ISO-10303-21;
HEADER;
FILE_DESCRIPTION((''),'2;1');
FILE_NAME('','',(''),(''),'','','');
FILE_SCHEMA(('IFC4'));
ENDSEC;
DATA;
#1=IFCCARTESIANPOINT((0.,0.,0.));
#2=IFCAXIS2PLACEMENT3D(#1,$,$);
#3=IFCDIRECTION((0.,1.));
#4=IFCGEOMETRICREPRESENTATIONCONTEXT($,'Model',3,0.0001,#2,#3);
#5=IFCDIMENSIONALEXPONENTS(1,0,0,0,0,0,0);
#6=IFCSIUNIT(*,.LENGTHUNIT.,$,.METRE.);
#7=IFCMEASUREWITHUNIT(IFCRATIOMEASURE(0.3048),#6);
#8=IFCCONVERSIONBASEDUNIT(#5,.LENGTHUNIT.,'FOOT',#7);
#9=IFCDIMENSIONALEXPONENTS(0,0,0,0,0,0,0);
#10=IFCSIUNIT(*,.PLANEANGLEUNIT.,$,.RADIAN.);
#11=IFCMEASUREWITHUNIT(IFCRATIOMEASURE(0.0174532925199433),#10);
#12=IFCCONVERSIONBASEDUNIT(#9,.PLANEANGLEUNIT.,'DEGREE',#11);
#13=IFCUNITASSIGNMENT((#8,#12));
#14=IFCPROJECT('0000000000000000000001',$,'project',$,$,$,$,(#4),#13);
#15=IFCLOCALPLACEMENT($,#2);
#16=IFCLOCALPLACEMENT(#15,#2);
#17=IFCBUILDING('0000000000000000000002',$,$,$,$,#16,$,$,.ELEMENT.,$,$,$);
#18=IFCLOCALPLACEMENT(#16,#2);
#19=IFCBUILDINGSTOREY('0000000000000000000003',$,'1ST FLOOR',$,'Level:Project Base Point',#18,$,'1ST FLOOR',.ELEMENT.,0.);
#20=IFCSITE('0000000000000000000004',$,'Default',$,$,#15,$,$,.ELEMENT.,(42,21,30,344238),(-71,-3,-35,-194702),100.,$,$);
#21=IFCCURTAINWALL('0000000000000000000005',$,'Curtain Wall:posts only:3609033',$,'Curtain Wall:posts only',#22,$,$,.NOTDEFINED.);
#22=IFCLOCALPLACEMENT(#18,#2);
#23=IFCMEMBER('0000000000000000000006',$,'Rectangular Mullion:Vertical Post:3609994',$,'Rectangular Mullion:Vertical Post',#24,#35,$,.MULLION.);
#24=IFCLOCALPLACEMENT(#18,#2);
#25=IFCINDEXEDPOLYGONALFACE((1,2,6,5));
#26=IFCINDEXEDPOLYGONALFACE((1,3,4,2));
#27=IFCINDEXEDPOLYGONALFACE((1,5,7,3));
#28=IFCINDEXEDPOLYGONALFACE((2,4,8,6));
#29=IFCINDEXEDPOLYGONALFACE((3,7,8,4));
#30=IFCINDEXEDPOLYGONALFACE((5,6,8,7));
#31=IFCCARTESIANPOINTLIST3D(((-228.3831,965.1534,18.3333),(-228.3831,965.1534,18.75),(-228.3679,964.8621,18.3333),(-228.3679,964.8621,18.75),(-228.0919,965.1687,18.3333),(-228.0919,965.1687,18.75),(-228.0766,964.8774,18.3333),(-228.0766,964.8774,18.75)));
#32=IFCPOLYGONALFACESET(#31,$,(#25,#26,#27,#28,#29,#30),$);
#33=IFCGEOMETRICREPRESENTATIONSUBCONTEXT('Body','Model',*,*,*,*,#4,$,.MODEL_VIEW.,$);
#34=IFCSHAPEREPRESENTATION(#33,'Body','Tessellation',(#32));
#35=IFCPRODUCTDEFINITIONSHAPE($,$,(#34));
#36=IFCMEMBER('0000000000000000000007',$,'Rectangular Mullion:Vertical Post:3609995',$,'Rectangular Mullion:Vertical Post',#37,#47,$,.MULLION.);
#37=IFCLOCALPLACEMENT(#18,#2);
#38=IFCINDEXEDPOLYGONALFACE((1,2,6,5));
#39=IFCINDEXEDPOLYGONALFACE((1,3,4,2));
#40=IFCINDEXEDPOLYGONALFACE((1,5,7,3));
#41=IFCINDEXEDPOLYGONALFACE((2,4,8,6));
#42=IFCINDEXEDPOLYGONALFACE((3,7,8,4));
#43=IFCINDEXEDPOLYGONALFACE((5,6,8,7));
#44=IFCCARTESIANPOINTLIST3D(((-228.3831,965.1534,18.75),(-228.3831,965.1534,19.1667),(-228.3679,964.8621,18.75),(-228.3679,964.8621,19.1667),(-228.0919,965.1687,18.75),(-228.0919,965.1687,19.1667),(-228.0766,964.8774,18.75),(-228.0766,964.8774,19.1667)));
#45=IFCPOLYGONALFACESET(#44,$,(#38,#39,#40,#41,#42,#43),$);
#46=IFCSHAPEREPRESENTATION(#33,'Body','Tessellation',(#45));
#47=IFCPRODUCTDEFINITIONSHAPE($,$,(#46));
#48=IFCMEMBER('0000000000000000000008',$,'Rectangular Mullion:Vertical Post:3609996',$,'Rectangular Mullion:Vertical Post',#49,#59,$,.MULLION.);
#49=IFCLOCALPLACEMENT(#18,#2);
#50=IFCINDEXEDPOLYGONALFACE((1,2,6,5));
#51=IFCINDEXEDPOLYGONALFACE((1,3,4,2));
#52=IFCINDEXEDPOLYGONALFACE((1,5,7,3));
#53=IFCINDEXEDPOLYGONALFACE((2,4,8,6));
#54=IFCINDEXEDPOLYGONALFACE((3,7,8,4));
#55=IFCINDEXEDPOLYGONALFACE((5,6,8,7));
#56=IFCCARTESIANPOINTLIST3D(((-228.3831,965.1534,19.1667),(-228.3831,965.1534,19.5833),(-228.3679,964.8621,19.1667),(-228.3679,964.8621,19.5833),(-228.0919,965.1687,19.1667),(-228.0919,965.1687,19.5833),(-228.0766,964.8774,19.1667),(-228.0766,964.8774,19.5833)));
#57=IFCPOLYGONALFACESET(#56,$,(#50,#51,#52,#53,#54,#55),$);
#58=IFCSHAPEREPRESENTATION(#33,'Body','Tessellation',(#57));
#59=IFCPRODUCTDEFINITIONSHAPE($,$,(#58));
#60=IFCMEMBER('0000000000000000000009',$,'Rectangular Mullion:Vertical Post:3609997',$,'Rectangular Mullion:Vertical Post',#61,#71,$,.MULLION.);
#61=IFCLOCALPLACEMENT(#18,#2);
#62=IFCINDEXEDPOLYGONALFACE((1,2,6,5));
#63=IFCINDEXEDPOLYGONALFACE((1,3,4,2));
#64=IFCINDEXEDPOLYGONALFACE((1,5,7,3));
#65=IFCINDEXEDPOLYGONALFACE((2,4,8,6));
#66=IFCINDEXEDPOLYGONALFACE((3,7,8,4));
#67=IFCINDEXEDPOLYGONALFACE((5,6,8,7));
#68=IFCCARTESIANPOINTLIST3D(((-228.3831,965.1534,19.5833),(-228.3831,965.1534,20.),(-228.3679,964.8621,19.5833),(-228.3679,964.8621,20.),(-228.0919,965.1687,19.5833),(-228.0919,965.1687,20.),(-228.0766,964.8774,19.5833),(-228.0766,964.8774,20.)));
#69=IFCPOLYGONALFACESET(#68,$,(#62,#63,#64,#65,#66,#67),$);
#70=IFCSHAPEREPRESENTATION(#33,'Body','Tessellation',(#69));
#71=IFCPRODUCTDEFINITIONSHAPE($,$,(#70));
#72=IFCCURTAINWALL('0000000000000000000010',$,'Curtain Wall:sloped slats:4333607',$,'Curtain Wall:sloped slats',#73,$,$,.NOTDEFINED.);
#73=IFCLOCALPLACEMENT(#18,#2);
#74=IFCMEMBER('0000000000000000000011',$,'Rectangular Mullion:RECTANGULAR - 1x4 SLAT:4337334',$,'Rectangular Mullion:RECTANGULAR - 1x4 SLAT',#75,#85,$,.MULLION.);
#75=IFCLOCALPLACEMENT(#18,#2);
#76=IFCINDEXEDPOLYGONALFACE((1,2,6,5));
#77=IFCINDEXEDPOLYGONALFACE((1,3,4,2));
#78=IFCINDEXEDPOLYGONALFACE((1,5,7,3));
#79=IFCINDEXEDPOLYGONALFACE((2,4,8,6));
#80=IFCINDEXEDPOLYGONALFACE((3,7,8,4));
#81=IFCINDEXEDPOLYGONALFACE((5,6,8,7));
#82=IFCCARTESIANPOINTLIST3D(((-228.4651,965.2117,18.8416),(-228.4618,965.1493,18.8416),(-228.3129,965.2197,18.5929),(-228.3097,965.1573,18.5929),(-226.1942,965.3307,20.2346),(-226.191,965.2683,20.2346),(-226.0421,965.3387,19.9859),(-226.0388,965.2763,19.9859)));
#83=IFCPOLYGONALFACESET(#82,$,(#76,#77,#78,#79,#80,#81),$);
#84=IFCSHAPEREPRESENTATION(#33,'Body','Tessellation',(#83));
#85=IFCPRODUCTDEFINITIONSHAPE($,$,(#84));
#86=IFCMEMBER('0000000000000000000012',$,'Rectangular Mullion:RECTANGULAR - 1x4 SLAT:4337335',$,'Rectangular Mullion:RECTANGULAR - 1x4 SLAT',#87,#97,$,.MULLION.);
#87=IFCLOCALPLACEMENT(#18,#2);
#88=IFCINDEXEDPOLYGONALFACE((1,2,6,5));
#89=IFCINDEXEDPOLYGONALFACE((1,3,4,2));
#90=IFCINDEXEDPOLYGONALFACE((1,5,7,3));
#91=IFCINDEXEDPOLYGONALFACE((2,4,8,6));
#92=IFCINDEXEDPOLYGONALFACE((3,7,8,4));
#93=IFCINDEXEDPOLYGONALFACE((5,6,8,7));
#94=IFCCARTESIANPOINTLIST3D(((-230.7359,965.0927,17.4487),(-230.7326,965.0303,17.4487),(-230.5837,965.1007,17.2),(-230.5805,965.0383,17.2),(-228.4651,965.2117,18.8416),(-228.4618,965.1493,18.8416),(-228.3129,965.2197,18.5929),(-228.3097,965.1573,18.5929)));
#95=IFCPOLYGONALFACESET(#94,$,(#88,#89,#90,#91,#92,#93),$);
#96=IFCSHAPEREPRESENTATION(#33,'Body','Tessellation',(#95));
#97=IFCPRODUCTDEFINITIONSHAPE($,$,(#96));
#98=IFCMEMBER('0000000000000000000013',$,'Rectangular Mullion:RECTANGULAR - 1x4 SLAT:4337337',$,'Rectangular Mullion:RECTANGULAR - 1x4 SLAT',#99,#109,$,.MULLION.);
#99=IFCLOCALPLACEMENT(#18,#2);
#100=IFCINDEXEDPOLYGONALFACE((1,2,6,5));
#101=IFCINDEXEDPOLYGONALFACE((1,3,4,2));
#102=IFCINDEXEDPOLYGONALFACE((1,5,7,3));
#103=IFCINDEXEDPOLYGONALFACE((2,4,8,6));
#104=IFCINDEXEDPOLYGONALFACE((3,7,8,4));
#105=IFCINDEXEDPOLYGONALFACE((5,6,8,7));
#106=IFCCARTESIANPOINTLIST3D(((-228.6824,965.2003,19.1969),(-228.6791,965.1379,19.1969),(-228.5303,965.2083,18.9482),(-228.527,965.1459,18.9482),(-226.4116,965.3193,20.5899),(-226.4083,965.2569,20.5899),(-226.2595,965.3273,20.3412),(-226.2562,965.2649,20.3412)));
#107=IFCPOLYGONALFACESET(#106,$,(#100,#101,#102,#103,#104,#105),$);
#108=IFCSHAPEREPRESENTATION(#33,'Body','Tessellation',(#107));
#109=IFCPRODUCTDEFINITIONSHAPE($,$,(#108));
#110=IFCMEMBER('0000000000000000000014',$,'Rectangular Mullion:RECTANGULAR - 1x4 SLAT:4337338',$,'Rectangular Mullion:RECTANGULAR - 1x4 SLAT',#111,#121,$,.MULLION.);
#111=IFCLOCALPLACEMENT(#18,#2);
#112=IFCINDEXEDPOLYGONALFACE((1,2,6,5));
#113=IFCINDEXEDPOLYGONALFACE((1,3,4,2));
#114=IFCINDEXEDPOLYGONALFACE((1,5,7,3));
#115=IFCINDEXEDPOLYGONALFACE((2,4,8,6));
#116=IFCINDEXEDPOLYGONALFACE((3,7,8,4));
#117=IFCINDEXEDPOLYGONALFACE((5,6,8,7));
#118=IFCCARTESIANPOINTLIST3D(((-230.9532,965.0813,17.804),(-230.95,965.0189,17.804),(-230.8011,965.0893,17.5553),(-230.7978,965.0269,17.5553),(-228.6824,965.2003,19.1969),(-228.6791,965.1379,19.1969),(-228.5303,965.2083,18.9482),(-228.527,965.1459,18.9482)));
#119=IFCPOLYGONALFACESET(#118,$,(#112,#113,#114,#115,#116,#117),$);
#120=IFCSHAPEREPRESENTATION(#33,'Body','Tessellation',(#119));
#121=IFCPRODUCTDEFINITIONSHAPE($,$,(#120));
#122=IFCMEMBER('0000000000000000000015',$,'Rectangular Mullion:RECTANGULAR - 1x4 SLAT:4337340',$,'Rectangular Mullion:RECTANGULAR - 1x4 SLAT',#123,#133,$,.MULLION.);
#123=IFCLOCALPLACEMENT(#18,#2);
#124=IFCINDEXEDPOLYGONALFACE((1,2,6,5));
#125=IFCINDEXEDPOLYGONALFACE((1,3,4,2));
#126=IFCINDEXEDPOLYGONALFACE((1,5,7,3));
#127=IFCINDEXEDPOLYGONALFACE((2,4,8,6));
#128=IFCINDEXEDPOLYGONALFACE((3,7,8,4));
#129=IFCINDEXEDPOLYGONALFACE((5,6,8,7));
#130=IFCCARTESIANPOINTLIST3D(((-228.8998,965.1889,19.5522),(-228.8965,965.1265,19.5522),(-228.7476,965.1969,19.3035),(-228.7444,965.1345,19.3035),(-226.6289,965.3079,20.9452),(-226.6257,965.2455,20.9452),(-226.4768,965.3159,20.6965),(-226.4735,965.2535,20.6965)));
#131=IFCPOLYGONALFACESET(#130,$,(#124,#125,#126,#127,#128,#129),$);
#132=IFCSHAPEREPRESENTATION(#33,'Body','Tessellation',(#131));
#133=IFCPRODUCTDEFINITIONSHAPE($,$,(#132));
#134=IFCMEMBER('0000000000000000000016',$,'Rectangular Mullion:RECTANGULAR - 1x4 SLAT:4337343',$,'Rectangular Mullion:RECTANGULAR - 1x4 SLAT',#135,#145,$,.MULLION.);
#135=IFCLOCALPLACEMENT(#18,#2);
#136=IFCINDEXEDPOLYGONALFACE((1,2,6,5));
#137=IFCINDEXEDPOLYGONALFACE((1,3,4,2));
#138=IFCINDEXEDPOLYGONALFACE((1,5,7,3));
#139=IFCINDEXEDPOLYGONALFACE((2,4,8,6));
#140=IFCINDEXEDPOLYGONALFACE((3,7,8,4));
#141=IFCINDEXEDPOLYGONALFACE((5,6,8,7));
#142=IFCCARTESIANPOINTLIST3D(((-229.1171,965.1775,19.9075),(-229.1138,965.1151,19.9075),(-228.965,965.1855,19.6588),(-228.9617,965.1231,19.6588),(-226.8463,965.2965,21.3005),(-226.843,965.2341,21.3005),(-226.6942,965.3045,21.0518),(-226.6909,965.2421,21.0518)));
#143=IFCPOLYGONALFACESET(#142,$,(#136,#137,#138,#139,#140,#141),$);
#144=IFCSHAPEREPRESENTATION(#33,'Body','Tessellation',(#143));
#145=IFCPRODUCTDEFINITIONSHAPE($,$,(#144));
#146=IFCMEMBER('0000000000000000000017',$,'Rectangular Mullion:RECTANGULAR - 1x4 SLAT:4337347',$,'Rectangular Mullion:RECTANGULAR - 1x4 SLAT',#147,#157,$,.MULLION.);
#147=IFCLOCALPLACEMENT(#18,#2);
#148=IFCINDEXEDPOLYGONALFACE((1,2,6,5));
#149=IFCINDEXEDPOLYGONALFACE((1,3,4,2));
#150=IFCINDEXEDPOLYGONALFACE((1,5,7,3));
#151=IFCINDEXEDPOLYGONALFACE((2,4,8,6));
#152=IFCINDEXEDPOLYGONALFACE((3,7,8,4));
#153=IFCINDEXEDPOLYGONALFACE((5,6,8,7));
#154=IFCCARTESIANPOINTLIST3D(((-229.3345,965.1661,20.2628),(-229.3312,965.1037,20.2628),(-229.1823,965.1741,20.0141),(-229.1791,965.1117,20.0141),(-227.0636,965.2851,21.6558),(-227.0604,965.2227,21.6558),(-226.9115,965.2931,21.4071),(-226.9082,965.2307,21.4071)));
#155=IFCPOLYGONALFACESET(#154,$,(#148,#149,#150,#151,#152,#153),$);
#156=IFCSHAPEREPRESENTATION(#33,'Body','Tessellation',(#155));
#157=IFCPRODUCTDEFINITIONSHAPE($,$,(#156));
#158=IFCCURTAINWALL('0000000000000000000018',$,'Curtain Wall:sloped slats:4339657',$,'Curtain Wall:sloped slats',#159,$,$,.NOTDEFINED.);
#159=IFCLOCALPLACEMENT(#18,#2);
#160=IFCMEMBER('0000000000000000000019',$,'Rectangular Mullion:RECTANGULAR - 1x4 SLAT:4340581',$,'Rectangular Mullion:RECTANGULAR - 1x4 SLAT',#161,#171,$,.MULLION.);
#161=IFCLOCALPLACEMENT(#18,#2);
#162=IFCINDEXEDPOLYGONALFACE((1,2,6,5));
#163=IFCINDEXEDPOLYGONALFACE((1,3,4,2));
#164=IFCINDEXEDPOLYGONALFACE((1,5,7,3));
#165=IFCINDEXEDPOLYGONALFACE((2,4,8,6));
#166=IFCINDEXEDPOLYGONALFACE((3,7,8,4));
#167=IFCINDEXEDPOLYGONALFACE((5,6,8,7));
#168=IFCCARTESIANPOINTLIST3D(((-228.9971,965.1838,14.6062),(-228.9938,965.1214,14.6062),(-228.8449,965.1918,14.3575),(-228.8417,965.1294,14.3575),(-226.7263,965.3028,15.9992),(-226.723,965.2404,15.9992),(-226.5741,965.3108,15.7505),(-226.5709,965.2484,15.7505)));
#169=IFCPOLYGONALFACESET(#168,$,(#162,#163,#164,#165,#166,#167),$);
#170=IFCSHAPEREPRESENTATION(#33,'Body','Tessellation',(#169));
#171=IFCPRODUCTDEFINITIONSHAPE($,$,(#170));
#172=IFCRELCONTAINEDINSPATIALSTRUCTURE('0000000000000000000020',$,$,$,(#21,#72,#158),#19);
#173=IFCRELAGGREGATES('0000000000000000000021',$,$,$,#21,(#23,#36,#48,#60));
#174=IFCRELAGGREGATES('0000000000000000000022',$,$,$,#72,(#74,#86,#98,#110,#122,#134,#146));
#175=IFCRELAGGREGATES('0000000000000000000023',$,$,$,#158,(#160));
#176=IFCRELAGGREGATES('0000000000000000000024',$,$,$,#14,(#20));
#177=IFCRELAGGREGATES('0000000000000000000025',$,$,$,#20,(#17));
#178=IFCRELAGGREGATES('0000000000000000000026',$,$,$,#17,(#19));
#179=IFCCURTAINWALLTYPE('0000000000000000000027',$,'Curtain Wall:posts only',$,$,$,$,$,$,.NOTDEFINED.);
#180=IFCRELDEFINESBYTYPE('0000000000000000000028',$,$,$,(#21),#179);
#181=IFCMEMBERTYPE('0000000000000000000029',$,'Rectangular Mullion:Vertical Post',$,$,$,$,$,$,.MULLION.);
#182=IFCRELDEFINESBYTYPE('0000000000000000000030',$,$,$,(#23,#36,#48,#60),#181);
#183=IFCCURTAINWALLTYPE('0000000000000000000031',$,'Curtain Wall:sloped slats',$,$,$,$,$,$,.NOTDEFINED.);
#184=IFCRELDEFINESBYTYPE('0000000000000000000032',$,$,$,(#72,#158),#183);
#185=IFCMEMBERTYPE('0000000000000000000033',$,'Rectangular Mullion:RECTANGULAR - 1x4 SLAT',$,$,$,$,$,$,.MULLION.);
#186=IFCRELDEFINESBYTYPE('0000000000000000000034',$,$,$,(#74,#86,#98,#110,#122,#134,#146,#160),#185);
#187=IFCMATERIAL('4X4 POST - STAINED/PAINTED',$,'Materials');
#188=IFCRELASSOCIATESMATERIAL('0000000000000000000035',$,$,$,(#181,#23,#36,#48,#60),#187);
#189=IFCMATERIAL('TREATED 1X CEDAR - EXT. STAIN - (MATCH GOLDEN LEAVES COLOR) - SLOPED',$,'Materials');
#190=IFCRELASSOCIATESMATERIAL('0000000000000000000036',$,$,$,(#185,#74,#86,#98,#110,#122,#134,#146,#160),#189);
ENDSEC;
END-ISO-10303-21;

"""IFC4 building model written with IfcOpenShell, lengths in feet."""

from ifc_helpers import new_model, entity, si_unit, converted_unit, direction, frame, frame_2d, origin, origin_2d_with_axis, place, context, subcontext, project, spatial, rectangle, extrude, source, transform, mapped, material, material_profile, profile_set, profile_usage, type_object, type_shapes, element, aggregate, save


model = new_model("IFC4")

# Units and contexts
model_context = context("Model", 3, precision=0.0001, world=origin(), true_north=direction((0.0, 1.0)))
body_context = subcontext(model_context, "Body", "Model", "MODEL_VIEW")
ifc_project = project(units=[converted_unit("LENGTHUNIT", "FOOT", entity("IfcRatioMeasure", 0.3048), si_unit("LENGTHUNIT", "METRE"), dimensions=[1, 0, 0, 0, 0, 0, 0]), converted_unit("PLANEANGLEUNIT", "DEGREE", entity("IfcRatioMeasure", 0.0174532925199433), si_unit("PLANEANGLEUNIT", "RADIAN"), dimensions=[0, 0, 0, 0, 0, 0, 0])], contexts=[model_context])

# Site, building, storey
site_placement = place(None, origin())
site = spatial("IfcSite", under=ifc_project, at=site_placement, Name="Default", CompositionType="ELEMENT", RefLatitude=(42, 21, 30, 344238), RefLongitude=(-71, -3, -35, -194702), RefElevation=100.0)
building_placement = place(site_placement, origin())
building = spatial("IfcBuilding", under=site, at=building_placement, CompositionType="ELEMENT")
storey_placement = place(building_placement, origin())
storey = spatial("IfcBuildingStorey", under=building, at=storey_placement, Name="1ST FLOOR", ObjectType="Level:Project Base Point", LongName="1ST FLOOR", CompositionType="ELEMENT", Elevation=0.0)

# Curtain walls, members
curtain_wall_type_1 = type_object("IfcCurtainWallType", Name="Curtain Wall:posts only", PredefinedType="NOTDEFINED")
curtain_wall_1_placement = place(storey_placement, origin())
curtain_wall_1 = element("IfcCurtainWall", 1, at=curtain_wall_1_placement, inside=storey, type_object=curtain_wall_type_1, Name="Curtain Wall:posts only:3609033", ObjectType="Curtain Wall:posts only", PredefinedType="NOTDEFINED")
ifc_material_1 = material(Name="4X4 POST - STAINED/PAINTED", Category="Materials")
ifc_material_profile_1 = material_profile(ifc_material_1, rectangle(XDim=0.2917, YDim=0.2917, at=origin_2d_with_axis()), Name="Vertical Post")
ifc_profile_set_1 = profile_set([ifc_material_profile_1], Name="Vertical Post")
member_type_1 = type_object("IfcMemberType", Name="Rectangular Mullion:Vertical Post", PredefinedType="MULLION", material=ifc_profile_set_1)
shared_shape_1 = source(origin(), body_context, "Body", "SweptSolid", [
    extrude(rectangle(XDim=0.2917, YDim=0.2917, at=origin_2d_with_axis()), frame((0.0, -0.2083, -0.4167), z_axis=(0.0, 0.0, 1.0), x_axis=(0.0, -1.0, 0.0)), (0.0, 0.0, 1.0), 0.4167),
])
type_shapes(member_type_1, [shared_shape_1])
ifc_profile_usage_1 = profile_usage(ifc_profile_set_1)
member_1_placement = place(storey_placement, frame((-228.2408, 965.2235, 18.3333), z_axis=(0.0, 0.0, -1.0), x_axis=(-0.99863, -0.052336, 0.0)))
member_1 = element("IfcMember", 2, at=member_1_placement, type_object=member_type_1, material=ifc_profile_usage_1, Name="Rectangular Mullion:Vertical Post:3609994", ObjectType="Rectangular Mullion:Vertical Post", PredefinedType="MULLION", context=body_context, shape_type="MappedRepresentation", body=[
    mapped(shared_shape_1, transform((0.0, 0.0, 0.0), scale=1.0)),
])
ifc_profile_usage_2 = profile_usage(ifc_profile_set_1)
member_2_placement = place(storey_placement, frame((-228.2408, 965.2235, 18.75), z_axis=(0.0, 0.0, -1.0), x_axis=(-0.99863, -0.052336, 0.0)))
member_2 = element("IfcMember", 3, at=member_2_placement, type_object=member_type_1, material=ifc_profile_usage_2, Name="Rectangular Mullion:Vertical Post:3609995", ObjectType="Rectangular Mullion:Vertical Post", PredefinedType="MULLION", context=body_context, shape_type="MappedRepresentation", body=[
    mapped(shared_shape_1, transform((0.0, 0.0, 0.0), scale=1.0)),
])
ifc_profile_usage_3 = profile_usage(ifc_profile_set_1)
member_3_placement = place(storey_placement, frame((-228.2408, 965.2235, 19.1667), z_axis=(0.0, 0.0, -1.0), x_axis=(-0.99863, -0.052336, 0.0)))
member_3 = element("IfcMember", 4, at=member_3_placement, type_object=member_type_1, material=ifc_profile_usage_3, Name="Rectangular Mullion:Vertical Post:3609996", ObjectType="Rectangular Mullion:Vertical Post", PredefinedType="MULLION", context=body_context, shape_type="MappedRepresentation", body=[
    mapped(shared_shape_1, transform((0.0, 0.0, 0.0), scale=1.0)),
])
ifc_profile_usage_4 = profile_usage(ifc_profile_set_1)
member_4_placement = place(storey_placement, frame((-228.2408, 965.2235, 19.5833), z_axis=(0.0, 0.0, -1.0), x_axis=(-0.99863, -0.052336, 0.0)))
member_4 = element("IfcMember", 5, at=member_4_placement, type_object=member_type_1, material=ifc_profile_usage_4, Name="Rectangular Mullion:Vertical Post:3609997", ObjectType="Rectangular Mullion:Vertical Post", PredefinedType="MULLION", context=body_context, shape_type="MappedRepresentation", body=[
    mapped(shared_shape_1, transform((0.0, 0.0, 0.0), scale=1.0)),
])
aggregate(curtain_wall_1, [member_1, member_2, member_3, member_4])
curtain_wall_type_2 = type_object("IfcCurtainWallType", Name="Curtain Wall:sloped slats", PredefinedType="NOTDEFINED")
curtain_wall_2_placement = place(storey_placement, origin())
curtain_wall_2 = element("IfcCurtainWall", 6, at=curtain_wall_2_placement, inside=storey, type_object=curtain_wall_type_2, Name="Curtain Wall:sloped slats:4333607", ObjectType="Curtain Wall:sloped slats", PredefinedType="NOTDEFINED")
ifc_material_2 = material(Name="TREATED 1X CEDAR - EXT. STAIN - (MATCH GOLDEN LEAVES COLOR) - SLOPED", Category="Materials")
ifc_material_profile_2 = material_profile(ifc_material_2, rectangle(XDim=0.0625, YDim=0.2917, at=frame_2d((0.0, 0.0), x_axis=(1.0, 0.0))), Name="RECTANGULAR - 1x4 SLAT")
ifc_profile_set_2 = profile_set([ifc_material_profile_2], Name="RECTANGULAR - 1x4 SLAT")
ifc_profile_usage_5 = profile_usage(ifc_profile_set_2)
member_type_2 = type_object("IfcMemberType", Name="Rectangular Mullion:RECTANGULAR - 1x4 SLAT", PredefinedType="MULLION", material=ifc_profile_set_2)
shared_shape_2 = source(origin(), body_context, "Body", "SweptSolid", [
    extrude(rectangle(XDim=0.0625, YDim=0.2917, at=frame_2d((0.0, 0.0), x_axis=(1.0, 0.0))), frame((0.0, 0.0, -2.6667), z_axis=(0.0, 0.0, 1.0), x_axis=(0.0, -1.0, 0.0)), (0.0, 0.0, 1.0), 2.6667),
])
type_shapes(member_type_2, [shared_shape_2])
member_5_placement = place(storey_placement, frame((-228.3874, 965.1845, 18.7173), z_axis=(-0.851559, -0.044628, -0.522356), x_axis=(-0.52164, -0.027338, 0.852727)))
member_5 = element("IfcMember", 7, at=member_5_placement, type_object=member_type_2, material=ifc_profile_usage_5, Name="Rectangular Mullion:RECTANGULAR - 1x4 SLAT:4337334", ObjectType="Rectangular Mullion:RECTANGULAR - 1x4 SLAT", PredefinedType="MULLION", context=body_context, shape_type="MappedRepresentation", body=[
    mapped(shared_shape_2, transform((0.0, 0.0, 0.0), scale=1.0)),
])
ifc_profile_usage_6 = profile_usage(ifc_profile_set_2)
member_6_placement = place(storey_placement, frame((-230.6582, 965.0655, 17.3243), z_axis=(-0.851559, -0.044628, -0.522356), x_axis=(-0.52164, -0.027338, 0.852727)))
member_6 = element("IfcMember", 8, at=member_6_placement, type_object=member_type_2, material=ifc_profile_usage_6, Name="Rectangular Mullion:RECTANGULAR - 1x4 SLAT:4337335", ObjectType="Rectangular Mullion:RECTANGULAR - 1x4 SLAT", PredefinedType="MULLION", context=body_context, shape_type="MappedRepresentation", body=[
    mapped(shared_shape_2, transform((0.0, 0.0, 0.0), scale=1.0)),
])
ifc_profile_usage_7 = profile_usage(ifc_profile_set_2)
member_7_placement = place(storey_placement, frame((-228.6047, 965.1731, 19.0726), z_axis=(-0.851559, -0.044628, -0.522356), x_axis=(-0.52164, -0.027338, 0.852727)))
member_7 = element("IfcMember", 9, at=member_7_placement, type_object=member_type_2, material=ifc_profile_usage_7, Name="Rectangular Mullion:RECTANGULAR - 1x4 SLAT:4337337", ObjectType="Rectangular Mullion:RECTANGULAR - 1x4 SLAT", PredefinedType="MULLION", context=body_context, shape_type="MappedRepresentation", body=[
    mapped(shared_shape_2, transform((0.0, 0.0, 0.0), scale=1.0)),
])
ifc_profile_usage_8 = profile_usage(ifc_profile_set_2)
member_8_placement = place(storey_placement, frame((-230.8755, 965.0541, 17.6796), z_axis=(-0.851559, -0.044628, -0.522356), x_axis=(-0.52164, -0.027338, 0.852727)))
member_8 = element("IfcMember", 10, at=member_8_placement, type_object=member_type_2, material=ifc_profile_usage_8, Name="Rectangular Mullion:RECTANGULAR - 1x4 SLAT:4337338", ObjectType="Rectangular Mullion:RECTANGULAR - 1x4 SLAT", PredefinedType="MULLION", context=body_context, shape_type="MappedRepresentation", body=[
    mapped(shared_shape_2, transform((0.0, 0.0, 0.0), scale=1.0)),
])
ifc_profile_usage_9 = profile_usage(ifc_profile_set_2)
member_9_placement = place(storey_placement, frame((-228.8221, 965.1617, 19.4279), z_axis=(-0.851559, -0.044628, -0.522356), x_axis=(-0.52164, -0.027338, 0.852727)))
member_9 = element("IfcMember", 11, at=member_9_placement, type_object=member_type_2, material=ifc_profile_usage_9, Name="Rectangular Mullion:RECTANGULAR - 1x4 SLAT:4337340", ObjectType="Rectangular Mullion:RECTANGULAR - 1x4 SLAT", PredefinedType="MULLION", context=body_context, shape_type="MappedRepresentation", body=[
    mapped(shared_shape_2, transform((0.0, 0.0, 0.0), scale=1.0)),
])
ifc_profile_usage_10 = profile_usage(ifc_profile_set_2)
member_10_placement = place(storey_placement, frame((-229.0394, 965.1503, 19.7832), z_axis=(-0.851559, -0.044628, -0.522356), x_axis=(-0.52164, -0.027338, 0.852727)))
member_10 = element("IfcMember", 12, at=member_10_placement, type_object=member_type_2, material=ifc_profile_usage_10, Name="Rectangular Mullion:RECTANGULAR - 1x4 SLAT:4337343", ObjectType="Rectangular Mullion:RECTANGULAR - 1x4 SLAT", PredefinedType="MULLION", context=body_context, shape_type="MappedRepresentation", body=[
    mapped(shared_shape_2, transform((0.0, 0.0, 0.0), scale=1.0)),
])
ifc_profile_usage_11 = profile_usage(ifc_profile_set_2)
member_11_placement = place(storey_placement, frame((-229.2568, 965.1389, 20.1385), z_axis=(-0.851559, -0.044628, -0.522356), x_axis=(-0.52164, -0.027338, 0.852727)))
member_11 = element("IfcMember", 13, at=member_11_placement, type_object=member_type_2, material=ifc_profile_usage_11, Name="Rectangular Mullion:RECTANGULAR - 1x4 SLAT:4337347", ObjectType="Rectangular Mullion:RECTANGULAR - 1x4 SLAT", PredefinedType="MULLION", context=body_context, shape_type="MappedRepresentation", body=[
    mapped(shared_shape_2, transform((0.0, 0.0, 0.0), scale=1.0)),
])
aggregate(curtain_wall_2, [member_5, member_6, member_7, member_8, member_9, member_10, member_11])
curtain_wall_3_placement = place(storey_placement, origin())
curtain_wall_3 = element("IfcCurtainWall", 14, at=curtain_wall_3_placement, inside=storey, type_object=curtain_wall_type_2, Name="Curtain Wall:sloped slats:4339657", ObjectType="Curtain Wall:sloped slats", PredefinedType="NOTDEFINED")
ifc_profile_usage_12 = profile_usage(ifc_profile_set_2)
member_12_placement = place(storey_placement, frame((-228.9194, 965.1566, 14.4819), z_axis=(-0.851559, -0.044628, -0.522356), x_axis=(-0.52164, -0.027338, 0.852727)))
member_12 = element("IfcMember", 15, at=member_12_placement, type_object=member_type_2, material=ifc_profile_usage_12, Name="Rectangular Mullion:RECTANGULAR - 1x4 SLAT:4340581", ObjectType="Rectangular Mullion:RECTANGULAR - 1x4 SLAT", PredefinedType="MULLION", context=body_context, shape_type="MappedRepresentation", body=[
    mapped(shared_shape_2, transform((0.0, 0.0, 0.0), scale=1.0)),
])
aggregate(curtain_wall_3, [member_12])

save(model, "model.ifc")
